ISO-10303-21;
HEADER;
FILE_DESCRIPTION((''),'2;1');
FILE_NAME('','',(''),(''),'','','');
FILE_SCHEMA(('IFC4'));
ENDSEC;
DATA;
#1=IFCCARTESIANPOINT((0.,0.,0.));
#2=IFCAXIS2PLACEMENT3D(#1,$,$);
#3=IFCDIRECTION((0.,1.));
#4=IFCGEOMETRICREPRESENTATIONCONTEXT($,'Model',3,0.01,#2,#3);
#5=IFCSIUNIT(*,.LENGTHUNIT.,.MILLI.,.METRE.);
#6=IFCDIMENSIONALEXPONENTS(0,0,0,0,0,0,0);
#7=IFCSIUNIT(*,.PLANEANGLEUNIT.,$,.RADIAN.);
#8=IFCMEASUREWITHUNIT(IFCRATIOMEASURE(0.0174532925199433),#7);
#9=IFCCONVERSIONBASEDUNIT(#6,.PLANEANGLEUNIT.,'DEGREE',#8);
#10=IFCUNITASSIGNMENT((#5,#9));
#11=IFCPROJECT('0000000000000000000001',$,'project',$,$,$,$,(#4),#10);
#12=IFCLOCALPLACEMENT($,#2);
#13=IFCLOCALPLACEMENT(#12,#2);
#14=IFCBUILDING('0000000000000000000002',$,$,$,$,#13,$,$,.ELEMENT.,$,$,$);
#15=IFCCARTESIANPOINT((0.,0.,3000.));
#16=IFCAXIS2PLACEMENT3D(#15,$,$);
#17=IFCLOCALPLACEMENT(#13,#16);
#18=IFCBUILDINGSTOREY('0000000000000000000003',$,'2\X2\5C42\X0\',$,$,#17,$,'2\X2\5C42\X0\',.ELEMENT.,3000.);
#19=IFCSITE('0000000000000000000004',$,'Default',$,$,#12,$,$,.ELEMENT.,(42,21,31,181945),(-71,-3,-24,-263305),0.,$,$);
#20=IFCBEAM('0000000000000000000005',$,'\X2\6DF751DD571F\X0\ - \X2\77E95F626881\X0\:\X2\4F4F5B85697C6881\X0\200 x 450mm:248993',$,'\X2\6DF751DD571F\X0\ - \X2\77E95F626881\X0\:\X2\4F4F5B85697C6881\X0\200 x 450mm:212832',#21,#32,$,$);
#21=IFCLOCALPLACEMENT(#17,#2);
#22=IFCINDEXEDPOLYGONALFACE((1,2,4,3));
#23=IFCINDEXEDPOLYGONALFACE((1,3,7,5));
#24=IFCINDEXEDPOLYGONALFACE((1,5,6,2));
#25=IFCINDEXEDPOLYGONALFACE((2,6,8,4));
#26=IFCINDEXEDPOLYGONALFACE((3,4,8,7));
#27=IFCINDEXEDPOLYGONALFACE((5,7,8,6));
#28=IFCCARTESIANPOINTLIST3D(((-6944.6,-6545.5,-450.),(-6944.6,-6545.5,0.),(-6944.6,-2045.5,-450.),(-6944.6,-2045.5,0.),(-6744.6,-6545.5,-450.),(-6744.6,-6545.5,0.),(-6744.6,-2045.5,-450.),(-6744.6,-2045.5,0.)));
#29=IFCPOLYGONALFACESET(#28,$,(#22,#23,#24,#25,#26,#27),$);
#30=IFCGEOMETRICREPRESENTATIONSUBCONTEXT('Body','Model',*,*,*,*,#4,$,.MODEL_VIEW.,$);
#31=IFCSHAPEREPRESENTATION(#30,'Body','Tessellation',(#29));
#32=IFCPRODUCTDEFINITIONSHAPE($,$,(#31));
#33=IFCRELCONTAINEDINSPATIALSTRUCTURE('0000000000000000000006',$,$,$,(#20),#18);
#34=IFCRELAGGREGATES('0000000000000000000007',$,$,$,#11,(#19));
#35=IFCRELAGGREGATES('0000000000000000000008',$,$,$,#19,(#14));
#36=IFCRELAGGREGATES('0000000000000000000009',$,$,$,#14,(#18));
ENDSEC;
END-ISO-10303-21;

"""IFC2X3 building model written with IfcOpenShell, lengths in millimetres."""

from ifc_helpers import new_model, entity, si_unit, converted_unit, direction, frame, frame_2d, origin, place, context, subcontext, project, spatial, rectangle, extrude, element, save


model = new_model("IFC2X3")

# Units and contexts
model_context = context("Model", 3, precision=0.01, world=origin(), true_north=direction((0.0, 1.0)))
body_context = subcontext(model_context, "Body", "Model", "MODEL_VIEW")
ifc_project = project(units=[si_unit("LENGTHUNIT", "METRE", prefix="MILLI"), converted_unit("PLANEANGLEUNIT", "DEGREE", entity("IfcRatioMeasure", 0.0174532925199433), si_unit("PLANEANGLEUNIT", "RADIAN"), dimensions=[0, 0, 0, 0, 0, 0, 0])], contexts=[model_context])

# Site, building, storey
site_placement = place(None, origin())
site = spatial("IfcSite", under=ifc_project, at=site_placement, Name="Default", CompositionType="ELEMENT", RefLatitude=(42, 21, 31, 181945), RefLongitude=(-71, -3, -24, -263305), RefElevation=0.0)
building_placement = place(site_placement, origin())
building = spatial("IfcBuilding", under=site, at=building_placement, CompositionType="ELEMENT")
storey_placement = place(building_placement, frame((0.0, 0.0, 3000.0)))
storey = spatial("IfcBuildingStorey", under=building, at=storey_placement, Name="2层", LongName="2层", CompositionType="ELEMENT", Elevation=3000.0)

# Beam
beam_1_placement = place(storey_placement, frame((-6844.6, -1945.5, 0.0), z_axis=(0.0, 0.0, 1.0), x_axis=(0.0, -1.0, 0.0)))
element("IfcBeam", 1, at=beam_1_placement, inside=storey, Name="混凝土 - 矩形梁:住宅楼梁200 x 450mm:248993", ObjectType="混凝土 - 矩形梁:住宅楼梁200 x 450mm:212832", context=body_context, shape_type="SweptSolid", body=[
    extrude(rectangle(XDim=450.0, YDim=200.0, at=frame_2d((0.0, 0.0), x_axis=(1.0, 0.0))), frame((100.0, 0.0, -225.0), z_axis=(1.0, 0.0, 0.0), x_axis=(0.0, 0.0, -1.0)), (0.0, 0.0, 1.0), 4500.0),
])

save(model, "model.ifc")
